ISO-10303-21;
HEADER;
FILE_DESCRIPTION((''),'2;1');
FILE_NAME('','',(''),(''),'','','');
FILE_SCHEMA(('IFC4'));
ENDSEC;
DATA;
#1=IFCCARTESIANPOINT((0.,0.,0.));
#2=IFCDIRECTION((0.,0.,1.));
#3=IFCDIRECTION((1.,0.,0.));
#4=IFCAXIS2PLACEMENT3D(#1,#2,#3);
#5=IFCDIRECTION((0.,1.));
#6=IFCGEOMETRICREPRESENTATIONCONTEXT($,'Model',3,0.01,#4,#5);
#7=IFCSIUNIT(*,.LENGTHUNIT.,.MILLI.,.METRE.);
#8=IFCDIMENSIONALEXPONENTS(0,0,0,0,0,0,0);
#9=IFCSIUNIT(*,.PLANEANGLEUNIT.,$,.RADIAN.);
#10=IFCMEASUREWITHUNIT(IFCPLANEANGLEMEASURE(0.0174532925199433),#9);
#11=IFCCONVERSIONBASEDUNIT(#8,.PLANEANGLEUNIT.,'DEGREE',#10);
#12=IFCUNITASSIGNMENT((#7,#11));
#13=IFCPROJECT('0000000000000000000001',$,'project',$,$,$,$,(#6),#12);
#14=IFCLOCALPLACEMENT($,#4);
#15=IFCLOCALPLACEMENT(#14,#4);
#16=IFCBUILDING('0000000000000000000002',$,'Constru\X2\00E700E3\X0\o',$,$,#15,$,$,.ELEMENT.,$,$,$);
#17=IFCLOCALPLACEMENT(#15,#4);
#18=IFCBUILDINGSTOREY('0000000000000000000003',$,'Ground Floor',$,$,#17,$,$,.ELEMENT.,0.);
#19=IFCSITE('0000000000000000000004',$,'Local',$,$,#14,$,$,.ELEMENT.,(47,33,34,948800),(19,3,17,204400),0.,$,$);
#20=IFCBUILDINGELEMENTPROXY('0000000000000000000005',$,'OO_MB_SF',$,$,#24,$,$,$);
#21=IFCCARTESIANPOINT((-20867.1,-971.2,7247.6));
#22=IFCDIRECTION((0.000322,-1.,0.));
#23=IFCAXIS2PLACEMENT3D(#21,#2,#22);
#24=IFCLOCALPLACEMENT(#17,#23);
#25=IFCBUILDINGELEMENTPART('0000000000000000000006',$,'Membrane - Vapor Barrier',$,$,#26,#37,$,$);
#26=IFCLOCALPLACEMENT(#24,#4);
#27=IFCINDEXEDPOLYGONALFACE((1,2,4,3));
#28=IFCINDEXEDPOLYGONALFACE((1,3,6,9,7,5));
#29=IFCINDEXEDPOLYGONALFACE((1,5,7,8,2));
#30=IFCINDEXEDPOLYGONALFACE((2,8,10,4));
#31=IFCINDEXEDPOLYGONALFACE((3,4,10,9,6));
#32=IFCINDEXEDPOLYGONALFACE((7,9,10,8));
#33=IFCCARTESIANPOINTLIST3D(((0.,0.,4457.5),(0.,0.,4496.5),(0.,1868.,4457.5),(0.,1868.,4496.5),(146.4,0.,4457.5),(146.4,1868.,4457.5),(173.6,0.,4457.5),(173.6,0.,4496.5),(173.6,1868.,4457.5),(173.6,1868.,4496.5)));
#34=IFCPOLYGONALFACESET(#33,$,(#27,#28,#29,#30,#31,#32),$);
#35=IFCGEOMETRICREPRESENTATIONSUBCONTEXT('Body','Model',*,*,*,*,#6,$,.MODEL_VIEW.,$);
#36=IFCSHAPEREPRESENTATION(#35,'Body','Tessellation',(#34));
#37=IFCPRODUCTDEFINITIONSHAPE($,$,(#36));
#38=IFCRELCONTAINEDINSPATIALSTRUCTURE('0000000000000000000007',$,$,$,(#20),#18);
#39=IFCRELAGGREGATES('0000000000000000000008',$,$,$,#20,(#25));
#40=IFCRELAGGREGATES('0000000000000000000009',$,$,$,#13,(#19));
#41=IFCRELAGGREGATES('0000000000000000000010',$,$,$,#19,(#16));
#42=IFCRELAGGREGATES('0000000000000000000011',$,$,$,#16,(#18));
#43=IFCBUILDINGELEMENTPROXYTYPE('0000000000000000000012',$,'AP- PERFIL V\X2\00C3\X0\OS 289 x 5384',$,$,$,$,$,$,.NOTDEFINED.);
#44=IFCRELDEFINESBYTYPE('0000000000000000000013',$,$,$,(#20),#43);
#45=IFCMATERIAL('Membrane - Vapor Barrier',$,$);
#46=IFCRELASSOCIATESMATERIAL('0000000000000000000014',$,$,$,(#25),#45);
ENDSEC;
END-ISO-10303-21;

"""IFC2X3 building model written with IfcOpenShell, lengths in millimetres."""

from ifc_helpers import new_model, entity, si_unit, converted_unit, direction, frame, origin_with_axes, place, context, subcontext, project, spatial, polyline, outline, extrude, material, type_object, element, aggregate, save


model = new_model("IFC2X3")

# Units and contexts
model_context = context("Model", 3, precision=0.01, world=origin_with_axes(), true_north=direction((0.0, 1.0)))
body_context = subcontext(model_context, "Body", "Model", "MODEL_VIEW")
ifc_project = project(units=[si_unit("LENGTHUNIT", "METRE", prefix="MILLI"), converted_unit("PLANEANGLEUNIT", "DEGREE", entity("IfcPlaneAngleMeasure", 0.0174532925199433), si_unit("PLANEANGLEUNIT", "RADIAN"), dimensions=[0, 0, 0, 0, 0, 0, 0])], contexts=[model_context])

# Site, building, storey
site_placement = place(None, origin_with_axes())
site = spatial("IfcSite", under=ifc_project, at=site_placement, Name="Local", CompositionType="ELEMENT", RefLatitude=(47, 33, 34, 948800), RefLongitude=(19, 3, 17, 204400), RefElevation=0.0)
building_placement = place(site_placement, origin_with_axes())
building = spatial("IfcBuilding", under=site, at=building_placement, Name="Construção", CompositionType="ELEMENT")
storey_placement = place(building_placement, origin_with_axes())
storey = spatial("IfcBuildingStorey", under=building, at=storey_placement, Name="Ground Floor", CompositionType="ELEMENT", Elevation=0.0)

# Building element proxy, building element part
building_element_proxy_type = type_object("IfcBuildingElementProxyType", Name="AP- PERFIL VÃOS 289 x 5384", PredefinedType="NOTDEFINED")
ifc_material = material(Name="Membrane - Vapor Barrier")
proxy_1_placement = place(storey_placement, frame((-20867.1, -971.2, 7247.6), z_axis=(0.0, 0.0, 1.0), x_axis=(0.000322, -1.0, 0.0)))
proxy_1 = element("IfcBuildingElementProxy", 1, at=proxy_1_placement, inside=storey, type_object=building_element_proxy_type, Name="OO_MB_SF")
building_element_part_1_placement = place(proxy_1_placement, origin_with_axes())
building_element_part_1 = element("IfcBuildingElementPart", 2, at=building_element_part_1_placement, material=ifc_material, Name="Membrane - Vapor Barrier", context=body_context, shape_type="SweptSolid", body=[
    extrude(outline(polyline([(173.6, 4496.5), (0.0, 4496.5), (0.0, 4457.5), (146.4, 4457.5), (173.6, 4457.5), (173.6, 4496.5)])), frame((0.0, 1868.0, 0.0), z_axis=(0.0, -1.0, 0.0), x_axis=(1.0, 0.0, 0.0)), (0.0, 0.0, 1.0), 1868.0),
])
aggregate(proxy_1, [building_element_part_1])

save(model, "model.ifc")
